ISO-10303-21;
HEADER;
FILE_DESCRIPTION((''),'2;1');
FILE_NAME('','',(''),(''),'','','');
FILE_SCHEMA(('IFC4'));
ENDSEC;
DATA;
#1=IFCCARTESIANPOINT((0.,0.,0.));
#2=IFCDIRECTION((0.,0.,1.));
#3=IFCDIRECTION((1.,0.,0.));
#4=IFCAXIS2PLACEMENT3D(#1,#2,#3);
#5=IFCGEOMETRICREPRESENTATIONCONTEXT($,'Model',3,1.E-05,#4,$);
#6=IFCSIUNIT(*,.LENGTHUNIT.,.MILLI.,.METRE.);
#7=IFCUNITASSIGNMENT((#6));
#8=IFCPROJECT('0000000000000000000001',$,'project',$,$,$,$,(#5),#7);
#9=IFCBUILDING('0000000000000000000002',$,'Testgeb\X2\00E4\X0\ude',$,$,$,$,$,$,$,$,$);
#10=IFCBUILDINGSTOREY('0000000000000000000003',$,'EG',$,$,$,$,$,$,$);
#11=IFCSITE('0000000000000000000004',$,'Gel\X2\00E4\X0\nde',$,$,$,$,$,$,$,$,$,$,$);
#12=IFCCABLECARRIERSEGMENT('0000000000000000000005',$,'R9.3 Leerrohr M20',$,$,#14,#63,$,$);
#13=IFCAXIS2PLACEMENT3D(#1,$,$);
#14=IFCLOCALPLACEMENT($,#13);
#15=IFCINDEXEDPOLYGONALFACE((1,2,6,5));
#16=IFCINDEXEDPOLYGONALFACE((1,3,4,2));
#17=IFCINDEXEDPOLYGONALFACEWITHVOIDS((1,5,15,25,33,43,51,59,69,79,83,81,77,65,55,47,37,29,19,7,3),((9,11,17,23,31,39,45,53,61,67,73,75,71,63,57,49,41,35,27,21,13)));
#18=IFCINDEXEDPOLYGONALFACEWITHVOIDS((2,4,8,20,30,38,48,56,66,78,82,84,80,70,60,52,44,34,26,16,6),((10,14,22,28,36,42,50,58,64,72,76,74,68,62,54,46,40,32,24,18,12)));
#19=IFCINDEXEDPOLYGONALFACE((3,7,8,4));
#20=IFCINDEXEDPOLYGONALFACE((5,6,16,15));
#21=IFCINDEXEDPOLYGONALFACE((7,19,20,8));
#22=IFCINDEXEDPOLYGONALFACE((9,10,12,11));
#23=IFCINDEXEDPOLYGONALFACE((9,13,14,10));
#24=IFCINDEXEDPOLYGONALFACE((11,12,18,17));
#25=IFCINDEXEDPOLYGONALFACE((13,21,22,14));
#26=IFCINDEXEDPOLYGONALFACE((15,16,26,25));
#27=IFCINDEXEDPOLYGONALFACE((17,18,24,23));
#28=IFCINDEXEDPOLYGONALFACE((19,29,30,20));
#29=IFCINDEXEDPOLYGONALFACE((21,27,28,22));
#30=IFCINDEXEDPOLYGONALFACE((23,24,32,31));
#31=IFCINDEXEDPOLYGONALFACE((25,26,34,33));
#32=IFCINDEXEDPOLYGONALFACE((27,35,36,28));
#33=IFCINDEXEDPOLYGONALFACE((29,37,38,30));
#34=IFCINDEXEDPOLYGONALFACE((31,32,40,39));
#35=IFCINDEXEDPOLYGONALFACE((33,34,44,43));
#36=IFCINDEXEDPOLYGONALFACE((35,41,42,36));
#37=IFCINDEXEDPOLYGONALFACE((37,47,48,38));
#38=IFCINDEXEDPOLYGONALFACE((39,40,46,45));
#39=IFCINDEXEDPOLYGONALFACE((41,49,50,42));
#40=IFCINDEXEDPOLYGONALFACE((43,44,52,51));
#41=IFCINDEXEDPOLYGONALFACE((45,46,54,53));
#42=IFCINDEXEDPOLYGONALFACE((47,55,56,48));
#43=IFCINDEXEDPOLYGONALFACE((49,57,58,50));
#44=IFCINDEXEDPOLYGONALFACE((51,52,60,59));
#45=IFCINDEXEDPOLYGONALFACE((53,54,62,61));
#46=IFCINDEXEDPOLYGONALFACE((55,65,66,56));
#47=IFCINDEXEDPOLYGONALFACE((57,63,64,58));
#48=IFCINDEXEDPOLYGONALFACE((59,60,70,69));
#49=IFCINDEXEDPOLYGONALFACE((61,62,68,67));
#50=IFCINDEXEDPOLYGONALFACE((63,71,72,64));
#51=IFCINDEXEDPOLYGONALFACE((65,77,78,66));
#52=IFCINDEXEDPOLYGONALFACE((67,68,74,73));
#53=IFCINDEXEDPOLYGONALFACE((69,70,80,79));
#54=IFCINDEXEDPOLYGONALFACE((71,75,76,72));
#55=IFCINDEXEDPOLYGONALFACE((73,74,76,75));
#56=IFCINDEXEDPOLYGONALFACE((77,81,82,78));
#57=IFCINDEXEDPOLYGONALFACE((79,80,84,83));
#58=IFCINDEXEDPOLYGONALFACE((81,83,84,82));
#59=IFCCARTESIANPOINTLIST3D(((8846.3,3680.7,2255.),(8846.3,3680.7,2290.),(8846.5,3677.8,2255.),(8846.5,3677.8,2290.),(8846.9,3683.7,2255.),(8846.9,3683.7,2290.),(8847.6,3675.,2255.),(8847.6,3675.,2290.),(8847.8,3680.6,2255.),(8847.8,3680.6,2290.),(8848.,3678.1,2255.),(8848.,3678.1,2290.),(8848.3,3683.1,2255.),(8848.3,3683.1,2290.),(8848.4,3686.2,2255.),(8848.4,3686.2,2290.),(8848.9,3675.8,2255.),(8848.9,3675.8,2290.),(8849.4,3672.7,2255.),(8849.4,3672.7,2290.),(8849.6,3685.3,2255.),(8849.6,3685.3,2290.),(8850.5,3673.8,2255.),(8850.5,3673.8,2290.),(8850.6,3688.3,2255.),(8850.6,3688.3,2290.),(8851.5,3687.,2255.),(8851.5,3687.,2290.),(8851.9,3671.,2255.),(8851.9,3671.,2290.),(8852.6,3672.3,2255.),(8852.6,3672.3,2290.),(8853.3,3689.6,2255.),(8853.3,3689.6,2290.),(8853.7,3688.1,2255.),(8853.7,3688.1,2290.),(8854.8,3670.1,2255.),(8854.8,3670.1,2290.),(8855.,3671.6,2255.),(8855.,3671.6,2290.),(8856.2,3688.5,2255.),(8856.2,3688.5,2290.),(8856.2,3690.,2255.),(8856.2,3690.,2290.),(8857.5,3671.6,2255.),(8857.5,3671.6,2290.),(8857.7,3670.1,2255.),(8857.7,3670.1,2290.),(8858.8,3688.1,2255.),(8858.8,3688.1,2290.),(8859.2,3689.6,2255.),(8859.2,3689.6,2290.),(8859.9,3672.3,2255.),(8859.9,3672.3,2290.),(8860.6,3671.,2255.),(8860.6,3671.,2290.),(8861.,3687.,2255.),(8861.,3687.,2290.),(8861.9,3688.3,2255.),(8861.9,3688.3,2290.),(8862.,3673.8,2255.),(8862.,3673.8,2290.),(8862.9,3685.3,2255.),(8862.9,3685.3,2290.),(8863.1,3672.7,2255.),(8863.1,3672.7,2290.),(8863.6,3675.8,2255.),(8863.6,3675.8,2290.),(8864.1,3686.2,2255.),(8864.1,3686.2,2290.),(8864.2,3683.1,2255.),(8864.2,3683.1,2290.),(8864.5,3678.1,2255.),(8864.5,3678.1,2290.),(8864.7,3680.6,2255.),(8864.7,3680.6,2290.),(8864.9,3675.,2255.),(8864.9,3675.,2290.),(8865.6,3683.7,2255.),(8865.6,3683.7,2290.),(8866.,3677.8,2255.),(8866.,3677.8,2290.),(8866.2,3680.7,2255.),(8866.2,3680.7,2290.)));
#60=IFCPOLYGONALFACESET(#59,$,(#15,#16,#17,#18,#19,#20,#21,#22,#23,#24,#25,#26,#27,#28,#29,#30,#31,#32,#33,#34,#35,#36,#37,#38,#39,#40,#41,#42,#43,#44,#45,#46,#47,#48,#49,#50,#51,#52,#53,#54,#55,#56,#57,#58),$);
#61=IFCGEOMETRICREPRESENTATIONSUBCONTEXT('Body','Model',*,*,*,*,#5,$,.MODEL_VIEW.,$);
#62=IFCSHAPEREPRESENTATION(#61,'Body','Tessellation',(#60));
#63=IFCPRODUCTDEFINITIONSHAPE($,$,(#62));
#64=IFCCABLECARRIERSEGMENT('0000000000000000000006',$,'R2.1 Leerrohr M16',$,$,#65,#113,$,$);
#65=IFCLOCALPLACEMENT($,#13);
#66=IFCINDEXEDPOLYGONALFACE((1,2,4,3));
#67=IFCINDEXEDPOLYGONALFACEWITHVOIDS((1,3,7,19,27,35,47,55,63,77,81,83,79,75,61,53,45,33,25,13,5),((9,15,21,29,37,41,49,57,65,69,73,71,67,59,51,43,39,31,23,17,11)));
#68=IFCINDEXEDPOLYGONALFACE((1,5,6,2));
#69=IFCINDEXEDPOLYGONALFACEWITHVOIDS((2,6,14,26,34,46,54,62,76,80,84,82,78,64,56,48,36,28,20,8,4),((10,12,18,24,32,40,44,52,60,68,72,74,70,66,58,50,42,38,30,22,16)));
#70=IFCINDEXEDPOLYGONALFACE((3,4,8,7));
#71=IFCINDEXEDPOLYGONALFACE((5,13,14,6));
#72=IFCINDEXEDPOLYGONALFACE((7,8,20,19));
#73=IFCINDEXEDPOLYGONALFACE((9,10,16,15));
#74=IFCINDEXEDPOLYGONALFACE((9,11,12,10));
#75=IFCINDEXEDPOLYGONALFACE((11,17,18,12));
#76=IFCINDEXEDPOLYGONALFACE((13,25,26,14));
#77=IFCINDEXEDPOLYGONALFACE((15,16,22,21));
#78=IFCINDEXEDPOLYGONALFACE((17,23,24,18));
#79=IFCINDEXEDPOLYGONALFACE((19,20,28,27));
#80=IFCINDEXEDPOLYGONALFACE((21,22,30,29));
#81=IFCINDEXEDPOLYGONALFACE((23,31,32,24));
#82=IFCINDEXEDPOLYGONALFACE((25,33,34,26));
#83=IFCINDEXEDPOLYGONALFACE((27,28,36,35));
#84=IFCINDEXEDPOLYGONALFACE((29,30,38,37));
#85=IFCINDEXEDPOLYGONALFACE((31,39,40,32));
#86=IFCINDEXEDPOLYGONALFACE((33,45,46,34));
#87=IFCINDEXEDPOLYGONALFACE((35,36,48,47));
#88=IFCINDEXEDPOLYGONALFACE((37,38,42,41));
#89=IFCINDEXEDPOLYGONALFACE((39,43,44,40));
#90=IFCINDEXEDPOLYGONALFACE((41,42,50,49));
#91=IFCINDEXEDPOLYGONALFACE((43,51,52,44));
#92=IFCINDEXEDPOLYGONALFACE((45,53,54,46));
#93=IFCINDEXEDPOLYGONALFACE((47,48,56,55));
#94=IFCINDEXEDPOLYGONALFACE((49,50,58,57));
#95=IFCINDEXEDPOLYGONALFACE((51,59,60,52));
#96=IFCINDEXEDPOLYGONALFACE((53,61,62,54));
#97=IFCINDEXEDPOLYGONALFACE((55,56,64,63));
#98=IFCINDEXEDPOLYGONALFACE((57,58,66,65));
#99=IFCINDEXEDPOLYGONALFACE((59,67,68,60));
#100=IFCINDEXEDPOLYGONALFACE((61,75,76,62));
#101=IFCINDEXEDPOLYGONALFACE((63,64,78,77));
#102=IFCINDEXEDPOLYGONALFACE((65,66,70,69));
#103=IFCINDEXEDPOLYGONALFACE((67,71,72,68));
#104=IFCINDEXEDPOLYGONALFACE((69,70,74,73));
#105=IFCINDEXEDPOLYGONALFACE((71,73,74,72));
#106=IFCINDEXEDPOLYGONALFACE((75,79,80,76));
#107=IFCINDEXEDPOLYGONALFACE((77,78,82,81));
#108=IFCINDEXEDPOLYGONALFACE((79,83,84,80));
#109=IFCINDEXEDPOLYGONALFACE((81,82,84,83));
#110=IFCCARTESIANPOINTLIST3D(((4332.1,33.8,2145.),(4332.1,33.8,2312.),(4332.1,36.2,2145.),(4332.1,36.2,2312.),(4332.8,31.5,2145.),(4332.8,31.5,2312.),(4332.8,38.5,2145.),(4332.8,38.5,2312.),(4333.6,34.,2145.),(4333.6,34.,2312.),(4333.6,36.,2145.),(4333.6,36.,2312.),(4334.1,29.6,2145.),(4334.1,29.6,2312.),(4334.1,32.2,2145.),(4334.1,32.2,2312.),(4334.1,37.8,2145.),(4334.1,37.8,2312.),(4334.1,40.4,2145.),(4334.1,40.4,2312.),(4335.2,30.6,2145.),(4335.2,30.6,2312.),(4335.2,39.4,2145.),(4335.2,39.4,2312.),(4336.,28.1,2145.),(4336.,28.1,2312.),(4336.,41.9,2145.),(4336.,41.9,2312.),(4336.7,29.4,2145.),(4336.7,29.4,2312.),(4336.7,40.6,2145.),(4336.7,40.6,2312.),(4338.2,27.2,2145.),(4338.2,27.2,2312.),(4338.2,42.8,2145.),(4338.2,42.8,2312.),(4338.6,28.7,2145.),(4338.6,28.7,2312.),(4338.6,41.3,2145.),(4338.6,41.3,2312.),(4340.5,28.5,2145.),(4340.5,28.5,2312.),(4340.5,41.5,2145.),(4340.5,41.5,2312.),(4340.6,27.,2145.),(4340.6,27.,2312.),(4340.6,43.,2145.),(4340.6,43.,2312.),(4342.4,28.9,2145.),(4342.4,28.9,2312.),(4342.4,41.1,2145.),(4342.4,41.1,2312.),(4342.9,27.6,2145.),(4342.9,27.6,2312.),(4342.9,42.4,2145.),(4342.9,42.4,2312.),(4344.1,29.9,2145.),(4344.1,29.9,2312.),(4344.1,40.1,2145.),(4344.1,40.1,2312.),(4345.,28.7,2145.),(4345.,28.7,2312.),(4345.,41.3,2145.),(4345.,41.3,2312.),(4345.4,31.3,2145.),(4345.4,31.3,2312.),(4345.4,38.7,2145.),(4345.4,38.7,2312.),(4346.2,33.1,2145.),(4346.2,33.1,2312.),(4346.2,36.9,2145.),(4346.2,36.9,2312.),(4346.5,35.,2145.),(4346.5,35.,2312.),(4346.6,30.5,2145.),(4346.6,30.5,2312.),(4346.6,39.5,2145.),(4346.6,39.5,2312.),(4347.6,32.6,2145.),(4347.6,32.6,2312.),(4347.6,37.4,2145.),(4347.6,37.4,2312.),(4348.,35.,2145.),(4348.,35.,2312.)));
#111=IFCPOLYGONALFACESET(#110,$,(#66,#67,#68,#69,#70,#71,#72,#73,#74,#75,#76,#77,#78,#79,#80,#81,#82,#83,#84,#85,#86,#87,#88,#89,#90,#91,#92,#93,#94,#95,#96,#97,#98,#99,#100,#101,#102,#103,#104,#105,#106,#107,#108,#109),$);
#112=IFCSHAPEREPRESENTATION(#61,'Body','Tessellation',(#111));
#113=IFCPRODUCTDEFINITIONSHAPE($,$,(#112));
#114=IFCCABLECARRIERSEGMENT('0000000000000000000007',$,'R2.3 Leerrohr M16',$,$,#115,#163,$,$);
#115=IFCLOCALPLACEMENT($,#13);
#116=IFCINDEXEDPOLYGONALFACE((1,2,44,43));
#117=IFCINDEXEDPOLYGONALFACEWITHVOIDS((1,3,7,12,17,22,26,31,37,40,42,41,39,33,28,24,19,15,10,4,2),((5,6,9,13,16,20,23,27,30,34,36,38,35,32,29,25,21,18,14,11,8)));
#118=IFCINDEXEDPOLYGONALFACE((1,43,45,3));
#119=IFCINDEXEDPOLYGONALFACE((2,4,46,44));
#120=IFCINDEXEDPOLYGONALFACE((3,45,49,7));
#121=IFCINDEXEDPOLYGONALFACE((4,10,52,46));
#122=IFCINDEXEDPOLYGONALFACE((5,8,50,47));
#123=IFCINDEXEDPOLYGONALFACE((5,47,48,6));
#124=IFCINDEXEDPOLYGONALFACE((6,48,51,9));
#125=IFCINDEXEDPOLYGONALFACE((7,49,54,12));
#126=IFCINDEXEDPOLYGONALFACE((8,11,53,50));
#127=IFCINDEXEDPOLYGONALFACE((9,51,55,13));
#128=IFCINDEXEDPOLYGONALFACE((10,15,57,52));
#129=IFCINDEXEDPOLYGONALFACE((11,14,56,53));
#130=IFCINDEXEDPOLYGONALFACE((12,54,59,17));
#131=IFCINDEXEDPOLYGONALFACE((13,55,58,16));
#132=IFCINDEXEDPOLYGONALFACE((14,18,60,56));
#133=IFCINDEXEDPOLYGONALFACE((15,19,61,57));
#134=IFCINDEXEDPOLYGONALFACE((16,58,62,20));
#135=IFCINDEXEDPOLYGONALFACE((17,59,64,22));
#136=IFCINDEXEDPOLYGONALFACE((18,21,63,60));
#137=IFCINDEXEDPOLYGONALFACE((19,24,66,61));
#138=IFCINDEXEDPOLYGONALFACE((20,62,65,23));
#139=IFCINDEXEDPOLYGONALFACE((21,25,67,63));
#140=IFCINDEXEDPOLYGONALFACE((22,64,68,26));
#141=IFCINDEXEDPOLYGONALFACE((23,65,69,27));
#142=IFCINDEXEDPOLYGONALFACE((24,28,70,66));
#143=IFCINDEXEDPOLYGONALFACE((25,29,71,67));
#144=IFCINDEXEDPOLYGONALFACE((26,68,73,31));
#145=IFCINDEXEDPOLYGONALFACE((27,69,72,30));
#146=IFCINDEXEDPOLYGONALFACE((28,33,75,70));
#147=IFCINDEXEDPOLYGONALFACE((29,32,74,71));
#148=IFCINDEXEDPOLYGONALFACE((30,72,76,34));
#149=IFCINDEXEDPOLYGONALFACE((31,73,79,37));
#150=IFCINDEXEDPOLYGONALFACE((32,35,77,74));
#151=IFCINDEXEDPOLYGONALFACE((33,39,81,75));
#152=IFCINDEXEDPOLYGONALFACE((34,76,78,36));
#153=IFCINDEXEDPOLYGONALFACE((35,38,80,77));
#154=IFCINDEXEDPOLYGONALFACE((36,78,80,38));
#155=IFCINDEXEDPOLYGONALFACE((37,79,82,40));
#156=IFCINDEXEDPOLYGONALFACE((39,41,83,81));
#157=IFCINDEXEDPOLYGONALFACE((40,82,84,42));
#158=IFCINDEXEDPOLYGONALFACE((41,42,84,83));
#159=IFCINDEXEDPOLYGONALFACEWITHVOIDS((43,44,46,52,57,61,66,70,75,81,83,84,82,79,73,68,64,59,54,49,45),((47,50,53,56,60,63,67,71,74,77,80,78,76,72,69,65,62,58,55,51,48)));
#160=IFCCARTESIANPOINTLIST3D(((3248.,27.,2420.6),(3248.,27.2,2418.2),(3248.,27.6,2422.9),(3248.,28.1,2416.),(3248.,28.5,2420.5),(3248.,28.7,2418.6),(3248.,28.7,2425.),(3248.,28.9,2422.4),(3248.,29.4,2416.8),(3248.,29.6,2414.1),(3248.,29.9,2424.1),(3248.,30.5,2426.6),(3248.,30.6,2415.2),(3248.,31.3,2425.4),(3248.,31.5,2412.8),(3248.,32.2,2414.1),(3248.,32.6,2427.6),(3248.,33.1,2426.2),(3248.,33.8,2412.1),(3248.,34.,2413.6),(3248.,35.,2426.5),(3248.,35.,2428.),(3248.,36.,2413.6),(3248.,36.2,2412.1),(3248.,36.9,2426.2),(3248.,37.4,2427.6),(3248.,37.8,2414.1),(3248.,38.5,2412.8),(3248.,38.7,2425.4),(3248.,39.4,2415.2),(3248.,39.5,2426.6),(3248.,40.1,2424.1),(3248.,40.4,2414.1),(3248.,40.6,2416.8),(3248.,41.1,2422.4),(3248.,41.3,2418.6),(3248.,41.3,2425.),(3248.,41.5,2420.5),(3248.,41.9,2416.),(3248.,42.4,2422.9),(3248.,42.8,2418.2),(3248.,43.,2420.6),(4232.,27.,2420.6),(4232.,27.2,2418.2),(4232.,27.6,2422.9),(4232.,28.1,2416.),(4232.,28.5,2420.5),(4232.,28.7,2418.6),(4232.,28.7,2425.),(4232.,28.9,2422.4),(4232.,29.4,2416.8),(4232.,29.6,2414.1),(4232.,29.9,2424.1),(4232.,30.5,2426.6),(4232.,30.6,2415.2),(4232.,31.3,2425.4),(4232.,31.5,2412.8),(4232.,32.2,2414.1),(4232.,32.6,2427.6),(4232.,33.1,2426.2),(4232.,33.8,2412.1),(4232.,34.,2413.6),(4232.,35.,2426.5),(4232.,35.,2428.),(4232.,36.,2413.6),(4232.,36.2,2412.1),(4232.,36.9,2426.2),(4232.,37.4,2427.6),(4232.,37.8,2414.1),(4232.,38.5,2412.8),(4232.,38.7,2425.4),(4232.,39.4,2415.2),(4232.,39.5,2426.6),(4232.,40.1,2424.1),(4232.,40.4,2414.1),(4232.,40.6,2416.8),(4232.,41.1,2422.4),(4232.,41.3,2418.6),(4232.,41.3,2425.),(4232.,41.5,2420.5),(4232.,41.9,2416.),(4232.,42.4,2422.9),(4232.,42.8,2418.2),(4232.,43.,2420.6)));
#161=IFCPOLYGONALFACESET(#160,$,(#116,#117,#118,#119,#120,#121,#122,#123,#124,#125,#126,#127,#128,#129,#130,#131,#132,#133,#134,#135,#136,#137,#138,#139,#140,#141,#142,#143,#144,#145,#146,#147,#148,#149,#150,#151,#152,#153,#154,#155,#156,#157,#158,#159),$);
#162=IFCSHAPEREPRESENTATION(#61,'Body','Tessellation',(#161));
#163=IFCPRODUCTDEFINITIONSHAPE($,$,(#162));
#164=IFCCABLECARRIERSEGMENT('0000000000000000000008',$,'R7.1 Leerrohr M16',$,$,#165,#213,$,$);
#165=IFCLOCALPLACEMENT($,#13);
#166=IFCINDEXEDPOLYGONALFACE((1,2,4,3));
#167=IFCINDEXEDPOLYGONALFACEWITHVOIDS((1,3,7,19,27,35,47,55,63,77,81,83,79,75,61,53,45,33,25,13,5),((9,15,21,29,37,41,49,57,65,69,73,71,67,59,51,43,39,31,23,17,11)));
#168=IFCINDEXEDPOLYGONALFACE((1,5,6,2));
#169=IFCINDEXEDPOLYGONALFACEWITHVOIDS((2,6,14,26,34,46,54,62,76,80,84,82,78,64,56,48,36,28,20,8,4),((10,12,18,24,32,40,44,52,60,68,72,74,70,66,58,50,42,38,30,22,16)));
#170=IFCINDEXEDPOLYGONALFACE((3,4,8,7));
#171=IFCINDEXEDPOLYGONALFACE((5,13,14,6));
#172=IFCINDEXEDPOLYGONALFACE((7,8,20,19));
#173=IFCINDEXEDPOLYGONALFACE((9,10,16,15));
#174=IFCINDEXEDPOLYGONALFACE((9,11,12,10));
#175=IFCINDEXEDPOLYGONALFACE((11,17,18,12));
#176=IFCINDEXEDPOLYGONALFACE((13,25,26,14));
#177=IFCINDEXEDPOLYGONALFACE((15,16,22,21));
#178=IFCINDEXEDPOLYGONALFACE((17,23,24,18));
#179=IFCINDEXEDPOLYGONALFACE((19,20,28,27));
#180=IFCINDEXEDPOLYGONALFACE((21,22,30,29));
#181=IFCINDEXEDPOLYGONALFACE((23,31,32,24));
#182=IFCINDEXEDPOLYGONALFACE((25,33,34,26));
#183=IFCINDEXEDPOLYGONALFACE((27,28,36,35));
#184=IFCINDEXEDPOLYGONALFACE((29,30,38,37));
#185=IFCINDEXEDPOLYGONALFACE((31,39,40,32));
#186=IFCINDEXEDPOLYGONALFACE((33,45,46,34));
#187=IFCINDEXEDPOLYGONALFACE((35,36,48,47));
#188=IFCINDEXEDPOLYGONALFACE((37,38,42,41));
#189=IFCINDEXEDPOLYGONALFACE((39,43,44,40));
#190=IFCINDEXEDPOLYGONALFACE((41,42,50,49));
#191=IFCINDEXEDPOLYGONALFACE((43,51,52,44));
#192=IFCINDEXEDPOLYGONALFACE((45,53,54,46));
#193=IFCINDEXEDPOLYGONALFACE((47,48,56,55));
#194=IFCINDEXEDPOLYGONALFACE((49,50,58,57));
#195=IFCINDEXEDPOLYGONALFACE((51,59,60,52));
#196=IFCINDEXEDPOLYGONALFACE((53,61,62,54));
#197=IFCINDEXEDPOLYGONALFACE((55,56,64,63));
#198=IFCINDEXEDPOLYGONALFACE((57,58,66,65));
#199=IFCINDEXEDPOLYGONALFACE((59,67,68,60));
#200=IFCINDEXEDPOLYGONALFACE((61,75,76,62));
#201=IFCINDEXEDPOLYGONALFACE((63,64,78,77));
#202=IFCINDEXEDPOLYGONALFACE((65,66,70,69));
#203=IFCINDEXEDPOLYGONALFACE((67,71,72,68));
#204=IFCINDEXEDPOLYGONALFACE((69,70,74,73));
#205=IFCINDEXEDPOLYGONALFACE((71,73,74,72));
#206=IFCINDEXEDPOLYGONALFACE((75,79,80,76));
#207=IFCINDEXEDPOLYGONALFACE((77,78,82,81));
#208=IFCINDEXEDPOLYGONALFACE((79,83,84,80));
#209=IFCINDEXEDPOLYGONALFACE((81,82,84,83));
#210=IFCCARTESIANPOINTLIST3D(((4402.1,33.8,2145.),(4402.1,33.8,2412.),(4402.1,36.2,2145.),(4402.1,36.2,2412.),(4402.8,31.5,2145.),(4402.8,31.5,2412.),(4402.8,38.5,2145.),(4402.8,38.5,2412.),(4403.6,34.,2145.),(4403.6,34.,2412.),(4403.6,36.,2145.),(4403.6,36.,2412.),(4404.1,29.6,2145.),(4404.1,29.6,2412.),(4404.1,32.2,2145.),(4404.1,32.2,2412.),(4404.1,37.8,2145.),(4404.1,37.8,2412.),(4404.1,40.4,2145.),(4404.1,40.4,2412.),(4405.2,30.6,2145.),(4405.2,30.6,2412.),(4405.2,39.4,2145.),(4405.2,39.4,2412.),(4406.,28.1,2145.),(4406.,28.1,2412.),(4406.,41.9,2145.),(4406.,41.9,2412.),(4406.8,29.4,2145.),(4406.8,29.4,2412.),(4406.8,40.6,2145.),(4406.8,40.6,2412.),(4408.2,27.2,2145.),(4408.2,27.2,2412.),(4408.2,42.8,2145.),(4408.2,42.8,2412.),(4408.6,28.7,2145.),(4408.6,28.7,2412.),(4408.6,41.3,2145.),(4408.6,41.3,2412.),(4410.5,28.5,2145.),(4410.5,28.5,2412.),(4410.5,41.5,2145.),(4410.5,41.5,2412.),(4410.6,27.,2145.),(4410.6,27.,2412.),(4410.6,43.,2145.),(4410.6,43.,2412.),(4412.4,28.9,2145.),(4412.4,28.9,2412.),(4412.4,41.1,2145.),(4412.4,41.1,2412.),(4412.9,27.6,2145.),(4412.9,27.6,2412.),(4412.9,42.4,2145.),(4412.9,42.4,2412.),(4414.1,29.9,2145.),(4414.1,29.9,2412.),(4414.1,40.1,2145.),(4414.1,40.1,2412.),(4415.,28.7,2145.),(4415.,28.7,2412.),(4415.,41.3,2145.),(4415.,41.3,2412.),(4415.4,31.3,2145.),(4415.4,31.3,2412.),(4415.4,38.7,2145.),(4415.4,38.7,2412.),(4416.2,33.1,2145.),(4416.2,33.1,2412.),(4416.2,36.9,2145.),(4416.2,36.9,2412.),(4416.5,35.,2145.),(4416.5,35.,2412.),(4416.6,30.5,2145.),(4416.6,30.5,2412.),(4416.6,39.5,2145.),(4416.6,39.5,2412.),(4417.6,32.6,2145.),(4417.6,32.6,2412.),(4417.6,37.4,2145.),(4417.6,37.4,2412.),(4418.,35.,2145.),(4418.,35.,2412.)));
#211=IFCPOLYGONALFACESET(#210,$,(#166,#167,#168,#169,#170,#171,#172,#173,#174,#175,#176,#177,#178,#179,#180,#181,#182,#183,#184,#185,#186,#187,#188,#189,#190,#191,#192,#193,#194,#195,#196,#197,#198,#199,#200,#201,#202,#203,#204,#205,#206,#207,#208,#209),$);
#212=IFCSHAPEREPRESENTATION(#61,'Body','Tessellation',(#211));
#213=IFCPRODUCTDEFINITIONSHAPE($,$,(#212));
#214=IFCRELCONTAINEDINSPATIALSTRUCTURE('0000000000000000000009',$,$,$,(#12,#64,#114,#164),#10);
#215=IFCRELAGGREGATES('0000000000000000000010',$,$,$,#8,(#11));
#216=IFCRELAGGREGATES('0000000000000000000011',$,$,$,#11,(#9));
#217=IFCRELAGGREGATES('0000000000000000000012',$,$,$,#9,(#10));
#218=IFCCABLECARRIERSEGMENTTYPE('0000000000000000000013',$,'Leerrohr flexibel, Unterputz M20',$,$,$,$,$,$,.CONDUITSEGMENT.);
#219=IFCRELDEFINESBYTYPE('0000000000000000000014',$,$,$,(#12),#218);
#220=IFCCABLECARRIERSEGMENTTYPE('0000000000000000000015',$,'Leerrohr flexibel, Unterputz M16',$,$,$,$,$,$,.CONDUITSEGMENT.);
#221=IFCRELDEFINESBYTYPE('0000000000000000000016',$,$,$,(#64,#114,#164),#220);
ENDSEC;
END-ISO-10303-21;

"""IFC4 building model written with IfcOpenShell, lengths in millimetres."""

from ifc_helpers import new_model, si_unit, frame, origin_with_axes, place, context, subcontext, project, spatial, hollow_circle, extrude, type_object, element, save


model = new_model("IFC4")

# Units and contexts
model_context = context("Model", 3, precision=1e-05, world=origin_with_axes())
body_context = subcontext(model_context, "Body", "Model", "MODEL_VIEW")
ifc_project = project(units=[si_unit("LENGTHUNIT", "METRE", prefix="MILLI")], contexts=[model_context])

# Site, building, storey
site = spatial("IfcSite", under=ifc_project, Name="Gelände")
building = spatial("IfcBuilding", under=site, Name="Testgebäude")
storey = spatial("IfcBuildingStorey", under=building, Name="EG")

# Cable carrier segment
cable_carrier_segment_type_1 = type_object("IfcCableCarrierSegmentType", Name="Leerrohr flexibel, Unterputz M20", PredefinedType="CONDUITSEGMENT")
cable_carrier_segment_1_placement = place(None, frame((8856.2, 3680.0, 2255.0), z_axis=(0.0, 0.0, 1.0), x_axis=(0.0, 1.0, 0.0)))
element("IfcCableCarrierSegment", 1, at=cable_carrier_segment_1_placement, inside=storey, type_object=cable_carrier_segment_type_1, Name="R9.3 Leerrohr M20", context=body_context, shape_type="SweptSolid", body=[
    extrude(hollow_circle(Radius=10.0, WallThickness=1.5), None, (0.0, 0.0, 1.0), 35.0),
])

# Cable carrier segments
cable_carrier_segment_type_2 = type_object("IfcCableCarrierSegmentType", Name="Leerrohr flexibel, Unterputz M16", PredefinedType="CONDUITSEGMENT")
cable_carrier_segment_2_placement = place(None, frame((4340.0, 35.0, 2145.0), z_axis=(0.0, 0.0, 1.0), x_axis=(1.0, 0.0, 0.0)))
element("IfcCableCarrierSegment", 2, at=cable_carrier_segment_2_placement, inside=storey, type_object=cable_carrier_segment_type_2, Name="R2.1 Leerrohr M16", context=body_context, shape_type="SweptSolid", body=[
    extrude(hollow_circle(Radius=8.0, WallThickness=1.5), None, (0.0, 0.0, 1.0), 167.0),
])
cable_carrier_segment_3_placement = place(None, frame((4232.0, 35.0, 2420.0), z_axis=(-1.0, 0.0, 0.0), x_axis=(0.0, 0.0, 1.0)))
element("IfcCableCarrierSegment", 3, at=cable_carrier_segment_3_placement, inside=storey, type_object=cable_carrier_segment_type_2, Name="R2.3 Leerrohr M16", context=body_context, shape_type="SweptSolid", body=[
    extrude(hollow_circle(Radius=8.0, WallThickness=1.5), None, (0.0, 0.0, 1.0), 984.0),
])
cable_carrier_segment_4_placement = place(None, frame((4410.0, 35.0, 2145.0), z_axis=(0.0, 0.0, 1.0), x_axis=(1.0, 0.0, 0.0)))
element("IfcCableCarrierSegment", 4, at=cable_carrier_segment_4_placement, inside=storey, type_object=cable_carrier_segment_type_2, Name="R7.1 Leerrohr M16", context=body_context, shape_type="SweptSolid", body=[
    extrude(hollow_circle(Radius=8.0, WallThickness=1.5), None, (0.0, 0.0, 1.0), 267.0),
])

save(model, "model.ifc")
